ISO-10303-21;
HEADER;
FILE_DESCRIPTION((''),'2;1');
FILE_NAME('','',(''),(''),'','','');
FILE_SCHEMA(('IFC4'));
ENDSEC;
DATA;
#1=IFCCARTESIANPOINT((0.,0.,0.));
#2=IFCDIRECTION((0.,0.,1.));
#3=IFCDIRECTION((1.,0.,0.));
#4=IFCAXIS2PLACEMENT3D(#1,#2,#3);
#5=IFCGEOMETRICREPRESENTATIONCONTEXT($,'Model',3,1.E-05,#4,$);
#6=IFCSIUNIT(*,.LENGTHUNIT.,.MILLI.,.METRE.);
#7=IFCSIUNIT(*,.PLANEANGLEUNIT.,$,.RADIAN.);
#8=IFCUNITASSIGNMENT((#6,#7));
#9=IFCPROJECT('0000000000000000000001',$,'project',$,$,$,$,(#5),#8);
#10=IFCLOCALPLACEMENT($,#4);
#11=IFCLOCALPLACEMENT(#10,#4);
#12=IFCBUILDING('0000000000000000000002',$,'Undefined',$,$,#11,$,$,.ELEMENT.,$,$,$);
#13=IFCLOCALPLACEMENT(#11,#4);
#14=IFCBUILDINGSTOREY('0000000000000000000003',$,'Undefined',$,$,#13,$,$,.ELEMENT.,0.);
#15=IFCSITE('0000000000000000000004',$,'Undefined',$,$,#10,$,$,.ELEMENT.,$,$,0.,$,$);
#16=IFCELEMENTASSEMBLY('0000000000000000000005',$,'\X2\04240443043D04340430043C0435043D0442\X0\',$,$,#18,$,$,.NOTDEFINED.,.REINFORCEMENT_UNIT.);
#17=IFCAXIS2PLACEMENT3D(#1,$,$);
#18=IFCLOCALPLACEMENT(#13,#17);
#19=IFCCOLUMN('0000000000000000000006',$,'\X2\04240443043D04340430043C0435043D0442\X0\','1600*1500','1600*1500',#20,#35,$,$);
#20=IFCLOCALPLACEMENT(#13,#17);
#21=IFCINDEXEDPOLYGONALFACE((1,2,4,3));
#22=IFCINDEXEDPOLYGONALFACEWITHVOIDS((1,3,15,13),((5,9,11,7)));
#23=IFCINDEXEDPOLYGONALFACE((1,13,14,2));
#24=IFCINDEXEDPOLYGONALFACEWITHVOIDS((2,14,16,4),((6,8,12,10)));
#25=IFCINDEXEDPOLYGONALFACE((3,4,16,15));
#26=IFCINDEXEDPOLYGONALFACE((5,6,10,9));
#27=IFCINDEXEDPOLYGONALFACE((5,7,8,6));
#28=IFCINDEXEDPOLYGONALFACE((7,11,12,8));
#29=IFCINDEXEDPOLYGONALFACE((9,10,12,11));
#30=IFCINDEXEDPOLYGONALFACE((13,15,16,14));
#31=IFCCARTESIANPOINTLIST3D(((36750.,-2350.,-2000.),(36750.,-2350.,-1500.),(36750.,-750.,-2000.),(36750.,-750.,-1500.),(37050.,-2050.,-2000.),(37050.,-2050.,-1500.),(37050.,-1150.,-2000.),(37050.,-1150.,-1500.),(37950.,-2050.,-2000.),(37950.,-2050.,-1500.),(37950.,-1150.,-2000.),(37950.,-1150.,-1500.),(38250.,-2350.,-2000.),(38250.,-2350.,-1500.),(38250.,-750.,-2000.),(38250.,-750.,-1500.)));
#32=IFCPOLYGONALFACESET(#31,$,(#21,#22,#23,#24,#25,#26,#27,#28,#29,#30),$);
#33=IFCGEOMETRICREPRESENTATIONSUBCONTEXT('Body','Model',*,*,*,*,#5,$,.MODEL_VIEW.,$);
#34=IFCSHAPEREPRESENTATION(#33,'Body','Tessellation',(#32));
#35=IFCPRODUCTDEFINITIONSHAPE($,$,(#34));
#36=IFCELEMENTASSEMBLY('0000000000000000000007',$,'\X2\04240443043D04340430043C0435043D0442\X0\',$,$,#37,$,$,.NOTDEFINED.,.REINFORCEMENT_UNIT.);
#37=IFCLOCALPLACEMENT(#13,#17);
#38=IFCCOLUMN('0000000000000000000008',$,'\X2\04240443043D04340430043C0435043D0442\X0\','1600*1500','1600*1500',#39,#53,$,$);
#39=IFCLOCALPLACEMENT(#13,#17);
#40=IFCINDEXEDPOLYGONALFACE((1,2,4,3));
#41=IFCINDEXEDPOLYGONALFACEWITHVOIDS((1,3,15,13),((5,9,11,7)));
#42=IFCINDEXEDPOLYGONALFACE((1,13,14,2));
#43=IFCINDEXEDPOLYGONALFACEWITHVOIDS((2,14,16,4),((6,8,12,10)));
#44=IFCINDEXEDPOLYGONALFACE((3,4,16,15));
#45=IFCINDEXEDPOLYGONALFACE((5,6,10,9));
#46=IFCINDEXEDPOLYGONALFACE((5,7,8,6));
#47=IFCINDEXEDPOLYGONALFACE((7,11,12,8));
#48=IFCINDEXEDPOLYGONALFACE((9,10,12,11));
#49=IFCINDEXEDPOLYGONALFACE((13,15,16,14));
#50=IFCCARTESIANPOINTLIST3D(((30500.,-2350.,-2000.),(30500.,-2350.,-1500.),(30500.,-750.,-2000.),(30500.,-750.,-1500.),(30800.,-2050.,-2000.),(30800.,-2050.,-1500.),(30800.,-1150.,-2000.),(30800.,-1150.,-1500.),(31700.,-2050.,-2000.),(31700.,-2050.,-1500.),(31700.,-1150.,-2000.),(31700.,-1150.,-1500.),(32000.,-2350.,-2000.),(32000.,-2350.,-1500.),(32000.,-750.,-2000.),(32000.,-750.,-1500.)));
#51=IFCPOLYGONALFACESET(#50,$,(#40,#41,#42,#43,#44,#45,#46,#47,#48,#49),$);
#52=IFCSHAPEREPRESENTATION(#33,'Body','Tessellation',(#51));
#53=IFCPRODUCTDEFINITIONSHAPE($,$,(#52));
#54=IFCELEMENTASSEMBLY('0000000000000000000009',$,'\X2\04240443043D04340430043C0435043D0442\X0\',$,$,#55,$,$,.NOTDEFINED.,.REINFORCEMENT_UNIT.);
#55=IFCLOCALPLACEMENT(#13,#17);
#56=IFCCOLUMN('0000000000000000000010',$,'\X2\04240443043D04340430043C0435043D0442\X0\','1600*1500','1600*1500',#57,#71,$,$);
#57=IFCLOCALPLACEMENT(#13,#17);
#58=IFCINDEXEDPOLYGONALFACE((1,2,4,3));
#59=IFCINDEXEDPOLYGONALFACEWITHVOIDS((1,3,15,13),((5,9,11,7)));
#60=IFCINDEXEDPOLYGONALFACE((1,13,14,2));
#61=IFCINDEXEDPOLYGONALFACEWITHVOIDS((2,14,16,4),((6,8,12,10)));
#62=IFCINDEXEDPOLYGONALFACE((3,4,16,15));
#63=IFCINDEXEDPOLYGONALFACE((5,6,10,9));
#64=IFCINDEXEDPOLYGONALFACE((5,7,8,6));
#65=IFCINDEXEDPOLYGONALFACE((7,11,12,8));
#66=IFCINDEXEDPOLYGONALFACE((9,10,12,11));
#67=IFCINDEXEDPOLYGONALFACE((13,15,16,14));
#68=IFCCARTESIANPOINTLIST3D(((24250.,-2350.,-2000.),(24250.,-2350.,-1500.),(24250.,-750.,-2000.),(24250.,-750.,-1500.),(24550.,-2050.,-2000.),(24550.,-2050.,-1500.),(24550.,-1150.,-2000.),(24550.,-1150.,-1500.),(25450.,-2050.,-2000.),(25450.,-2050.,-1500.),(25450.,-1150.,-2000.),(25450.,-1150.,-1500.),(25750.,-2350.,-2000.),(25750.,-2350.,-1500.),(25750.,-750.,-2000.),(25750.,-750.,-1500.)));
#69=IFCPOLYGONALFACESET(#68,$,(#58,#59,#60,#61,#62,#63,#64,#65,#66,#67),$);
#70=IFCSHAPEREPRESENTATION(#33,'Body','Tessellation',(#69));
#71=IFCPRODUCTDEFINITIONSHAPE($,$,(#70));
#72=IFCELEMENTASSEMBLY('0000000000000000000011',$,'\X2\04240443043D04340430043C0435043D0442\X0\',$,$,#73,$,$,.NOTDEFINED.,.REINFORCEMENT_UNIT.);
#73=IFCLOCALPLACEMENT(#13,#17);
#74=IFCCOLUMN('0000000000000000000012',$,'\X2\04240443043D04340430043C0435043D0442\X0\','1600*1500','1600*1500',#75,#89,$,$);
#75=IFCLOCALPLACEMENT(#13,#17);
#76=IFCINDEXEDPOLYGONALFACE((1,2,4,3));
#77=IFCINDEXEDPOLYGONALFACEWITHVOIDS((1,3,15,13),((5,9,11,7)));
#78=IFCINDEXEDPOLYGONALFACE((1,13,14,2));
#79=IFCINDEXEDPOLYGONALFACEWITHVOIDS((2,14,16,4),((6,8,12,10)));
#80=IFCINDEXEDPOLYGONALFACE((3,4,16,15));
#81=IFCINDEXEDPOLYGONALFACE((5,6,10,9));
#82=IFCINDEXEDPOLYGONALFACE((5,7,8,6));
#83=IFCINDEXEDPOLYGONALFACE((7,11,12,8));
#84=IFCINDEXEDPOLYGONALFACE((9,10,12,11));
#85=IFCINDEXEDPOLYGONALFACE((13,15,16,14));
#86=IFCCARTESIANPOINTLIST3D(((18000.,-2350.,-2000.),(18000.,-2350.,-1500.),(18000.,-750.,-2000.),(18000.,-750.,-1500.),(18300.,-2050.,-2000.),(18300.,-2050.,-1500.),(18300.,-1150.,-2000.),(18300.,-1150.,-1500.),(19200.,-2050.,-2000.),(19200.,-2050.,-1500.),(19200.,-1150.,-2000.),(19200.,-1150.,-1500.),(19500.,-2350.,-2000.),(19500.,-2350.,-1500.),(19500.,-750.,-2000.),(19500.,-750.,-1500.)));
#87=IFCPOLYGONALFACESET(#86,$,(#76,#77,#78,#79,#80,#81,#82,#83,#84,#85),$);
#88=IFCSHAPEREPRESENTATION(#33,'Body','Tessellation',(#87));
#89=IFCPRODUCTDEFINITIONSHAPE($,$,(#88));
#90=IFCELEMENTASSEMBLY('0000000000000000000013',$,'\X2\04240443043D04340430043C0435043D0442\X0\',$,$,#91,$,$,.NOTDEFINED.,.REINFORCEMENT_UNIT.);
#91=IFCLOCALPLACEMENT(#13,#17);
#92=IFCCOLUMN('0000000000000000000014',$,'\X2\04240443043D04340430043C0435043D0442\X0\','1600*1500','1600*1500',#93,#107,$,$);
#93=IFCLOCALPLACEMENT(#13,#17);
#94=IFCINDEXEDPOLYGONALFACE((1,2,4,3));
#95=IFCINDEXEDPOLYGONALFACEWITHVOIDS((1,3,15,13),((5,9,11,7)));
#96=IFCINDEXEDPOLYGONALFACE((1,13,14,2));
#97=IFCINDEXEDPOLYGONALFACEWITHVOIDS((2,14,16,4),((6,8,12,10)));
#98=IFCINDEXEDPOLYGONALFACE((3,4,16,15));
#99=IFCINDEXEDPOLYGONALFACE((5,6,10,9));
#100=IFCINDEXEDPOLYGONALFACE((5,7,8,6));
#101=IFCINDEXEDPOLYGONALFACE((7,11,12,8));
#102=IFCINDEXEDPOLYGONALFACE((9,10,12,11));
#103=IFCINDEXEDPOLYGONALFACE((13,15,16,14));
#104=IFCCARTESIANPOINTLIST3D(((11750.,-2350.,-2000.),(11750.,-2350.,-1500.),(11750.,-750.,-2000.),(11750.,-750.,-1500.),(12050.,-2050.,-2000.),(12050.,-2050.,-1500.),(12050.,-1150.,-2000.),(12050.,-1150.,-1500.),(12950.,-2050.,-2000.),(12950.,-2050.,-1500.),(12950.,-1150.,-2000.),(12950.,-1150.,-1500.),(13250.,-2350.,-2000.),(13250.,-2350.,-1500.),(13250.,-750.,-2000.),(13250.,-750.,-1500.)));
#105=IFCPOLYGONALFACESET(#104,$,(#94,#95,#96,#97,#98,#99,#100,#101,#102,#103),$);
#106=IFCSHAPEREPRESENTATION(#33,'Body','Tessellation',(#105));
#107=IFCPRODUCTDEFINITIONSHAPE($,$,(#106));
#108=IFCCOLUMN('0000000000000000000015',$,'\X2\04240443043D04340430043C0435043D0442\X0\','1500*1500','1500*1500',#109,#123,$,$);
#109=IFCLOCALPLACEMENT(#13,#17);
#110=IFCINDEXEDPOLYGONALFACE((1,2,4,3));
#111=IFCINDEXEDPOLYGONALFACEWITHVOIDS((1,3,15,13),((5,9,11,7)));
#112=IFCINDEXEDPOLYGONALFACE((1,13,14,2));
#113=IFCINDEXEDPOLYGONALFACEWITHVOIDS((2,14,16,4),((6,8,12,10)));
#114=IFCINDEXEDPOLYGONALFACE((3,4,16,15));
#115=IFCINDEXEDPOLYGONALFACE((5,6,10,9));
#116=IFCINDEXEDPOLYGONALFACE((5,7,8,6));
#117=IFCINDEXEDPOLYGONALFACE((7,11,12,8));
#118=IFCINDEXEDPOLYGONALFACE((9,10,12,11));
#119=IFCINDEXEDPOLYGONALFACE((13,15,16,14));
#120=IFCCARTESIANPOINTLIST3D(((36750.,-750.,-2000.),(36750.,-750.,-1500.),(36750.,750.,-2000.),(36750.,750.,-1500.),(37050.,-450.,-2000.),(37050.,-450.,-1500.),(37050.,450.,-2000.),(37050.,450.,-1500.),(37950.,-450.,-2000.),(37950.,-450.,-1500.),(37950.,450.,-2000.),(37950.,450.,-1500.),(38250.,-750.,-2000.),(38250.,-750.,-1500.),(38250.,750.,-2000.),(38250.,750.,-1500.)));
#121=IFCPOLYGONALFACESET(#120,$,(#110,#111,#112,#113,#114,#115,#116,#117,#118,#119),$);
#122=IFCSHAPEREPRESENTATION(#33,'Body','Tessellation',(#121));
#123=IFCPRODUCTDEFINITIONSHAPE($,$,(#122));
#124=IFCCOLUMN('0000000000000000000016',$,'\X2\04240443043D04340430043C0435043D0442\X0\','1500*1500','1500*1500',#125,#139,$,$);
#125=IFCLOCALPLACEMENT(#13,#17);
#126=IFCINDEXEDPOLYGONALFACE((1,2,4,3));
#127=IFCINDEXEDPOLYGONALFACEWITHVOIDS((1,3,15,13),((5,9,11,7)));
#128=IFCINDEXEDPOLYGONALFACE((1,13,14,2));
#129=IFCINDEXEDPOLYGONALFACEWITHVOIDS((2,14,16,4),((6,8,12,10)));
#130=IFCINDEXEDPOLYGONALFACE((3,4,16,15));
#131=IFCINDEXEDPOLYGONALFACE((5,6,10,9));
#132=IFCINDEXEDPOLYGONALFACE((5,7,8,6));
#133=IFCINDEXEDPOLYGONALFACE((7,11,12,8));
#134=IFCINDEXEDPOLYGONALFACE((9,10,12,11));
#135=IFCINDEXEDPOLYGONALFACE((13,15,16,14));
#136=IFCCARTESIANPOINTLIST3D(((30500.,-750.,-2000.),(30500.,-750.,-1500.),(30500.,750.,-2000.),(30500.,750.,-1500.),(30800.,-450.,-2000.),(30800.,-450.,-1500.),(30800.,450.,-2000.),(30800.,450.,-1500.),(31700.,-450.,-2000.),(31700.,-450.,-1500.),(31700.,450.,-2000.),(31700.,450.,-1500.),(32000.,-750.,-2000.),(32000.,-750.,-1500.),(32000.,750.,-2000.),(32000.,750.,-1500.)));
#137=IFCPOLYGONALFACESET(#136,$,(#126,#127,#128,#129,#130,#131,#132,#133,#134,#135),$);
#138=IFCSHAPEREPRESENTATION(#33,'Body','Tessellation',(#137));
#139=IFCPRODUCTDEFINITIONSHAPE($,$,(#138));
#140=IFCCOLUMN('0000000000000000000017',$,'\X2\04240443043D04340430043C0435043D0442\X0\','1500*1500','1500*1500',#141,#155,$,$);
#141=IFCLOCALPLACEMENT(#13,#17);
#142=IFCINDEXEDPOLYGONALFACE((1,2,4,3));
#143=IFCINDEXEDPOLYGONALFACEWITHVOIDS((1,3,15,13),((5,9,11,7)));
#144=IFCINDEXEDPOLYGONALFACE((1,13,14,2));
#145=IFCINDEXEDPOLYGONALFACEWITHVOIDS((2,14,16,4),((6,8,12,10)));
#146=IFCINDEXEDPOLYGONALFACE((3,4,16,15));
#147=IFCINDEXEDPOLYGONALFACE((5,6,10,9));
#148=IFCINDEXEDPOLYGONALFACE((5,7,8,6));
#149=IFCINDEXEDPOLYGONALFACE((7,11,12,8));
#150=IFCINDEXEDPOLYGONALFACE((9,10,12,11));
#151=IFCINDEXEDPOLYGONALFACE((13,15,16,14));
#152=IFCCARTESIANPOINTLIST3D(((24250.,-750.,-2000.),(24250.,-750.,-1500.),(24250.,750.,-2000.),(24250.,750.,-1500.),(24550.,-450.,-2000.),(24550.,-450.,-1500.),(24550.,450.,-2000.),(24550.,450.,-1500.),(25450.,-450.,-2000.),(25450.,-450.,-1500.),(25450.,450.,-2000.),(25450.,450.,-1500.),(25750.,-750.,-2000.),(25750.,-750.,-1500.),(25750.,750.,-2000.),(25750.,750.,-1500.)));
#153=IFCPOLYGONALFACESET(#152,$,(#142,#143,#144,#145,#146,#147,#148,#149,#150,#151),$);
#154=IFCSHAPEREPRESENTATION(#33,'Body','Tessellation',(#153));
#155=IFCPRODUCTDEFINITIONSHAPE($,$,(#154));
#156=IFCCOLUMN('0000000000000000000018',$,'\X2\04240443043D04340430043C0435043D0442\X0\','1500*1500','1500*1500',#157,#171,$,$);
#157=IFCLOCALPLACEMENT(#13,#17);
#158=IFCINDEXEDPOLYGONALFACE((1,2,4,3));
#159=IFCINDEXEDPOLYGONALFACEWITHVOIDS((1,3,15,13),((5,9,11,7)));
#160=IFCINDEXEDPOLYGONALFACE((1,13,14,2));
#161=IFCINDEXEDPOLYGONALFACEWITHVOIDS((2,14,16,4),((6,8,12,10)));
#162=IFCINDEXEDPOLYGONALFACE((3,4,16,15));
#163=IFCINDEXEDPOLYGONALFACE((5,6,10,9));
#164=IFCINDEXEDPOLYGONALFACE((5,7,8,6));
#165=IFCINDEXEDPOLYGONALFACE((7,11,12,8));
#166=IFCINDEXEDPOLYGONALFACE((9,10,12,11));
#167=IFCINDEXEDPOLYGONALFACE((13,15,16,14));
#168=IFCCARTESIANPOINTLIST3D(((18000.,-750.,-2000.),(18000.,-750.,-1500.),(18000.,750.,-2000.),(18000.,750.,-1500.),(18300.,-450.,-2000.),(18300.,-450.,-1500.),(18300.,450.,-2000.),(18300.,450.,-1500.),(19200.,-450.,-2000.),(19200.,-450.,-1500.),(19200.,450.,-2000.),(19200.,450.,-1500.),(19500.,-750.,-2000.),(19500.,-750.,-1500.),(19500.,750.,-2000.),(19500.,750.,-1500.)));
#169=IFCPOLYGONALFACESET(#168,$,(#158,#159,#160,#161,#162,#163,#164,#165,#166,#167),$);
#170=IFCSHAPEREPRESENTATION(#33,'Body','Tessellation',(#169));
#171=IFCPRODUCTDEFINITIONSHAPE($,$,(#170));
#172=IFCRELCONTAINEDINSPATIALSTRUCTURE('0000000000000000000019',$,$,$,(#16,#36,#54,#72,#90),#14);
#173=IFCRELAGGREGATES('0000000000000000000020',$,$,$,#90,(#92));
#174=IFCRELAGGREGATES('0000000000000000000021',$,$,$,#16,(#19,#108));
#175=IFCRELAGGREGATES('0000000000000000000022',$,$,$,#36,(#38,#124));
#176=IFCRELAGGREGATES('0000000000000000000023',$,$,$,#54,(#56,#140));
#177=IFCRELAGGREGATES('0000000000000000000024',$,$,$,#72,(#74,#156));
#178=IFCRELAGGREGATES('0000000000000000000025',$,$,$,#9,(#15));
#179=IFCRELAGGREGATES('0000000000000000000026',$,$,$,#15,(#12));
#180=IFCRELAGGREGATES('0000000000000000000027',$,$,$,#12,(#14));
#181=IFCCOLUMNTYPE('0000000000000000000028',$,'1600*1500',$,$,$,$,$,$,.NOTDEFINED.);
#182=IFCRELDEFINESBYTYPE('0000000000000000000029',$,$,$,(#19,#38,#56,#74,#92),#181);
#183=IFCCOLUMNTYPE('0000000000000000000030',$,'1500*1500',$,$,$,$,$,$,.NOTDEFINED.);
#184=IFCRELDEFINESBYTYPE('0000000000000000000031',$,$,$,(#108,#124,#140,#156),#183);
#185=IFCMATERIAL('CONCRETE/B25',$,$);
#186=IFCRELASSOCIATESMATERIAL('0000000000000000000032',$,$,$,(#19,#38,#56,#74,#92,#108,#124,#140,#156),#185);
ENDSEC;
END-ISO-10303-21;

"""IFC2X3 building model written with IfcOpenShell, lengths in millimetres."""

from ifc_helpers import new_model, si_unit, frame, origin_with_axes, origin_2d_with_axis, place, context, subcontext, project, spatial, polyline, rectangle, outline, extrude, boolean, material, type_object, element, aggregate, save


model = new_model("IFC2X3")

# Units and contexts
model_context = context("Model", 3, precision=1e-05, world=origin_with_axes())
body_context = subcontext(model_context, "Body", "Model", "MODEL_VIEW")
ifc_project = project(units=[si_unit("LENGTHUNIT", "METRE", prefix="MILLI"), si_unit("PLANEANGLEUNIT", "RADIAN")], contexts=[model_context])

# Site, building, storey
site_placement = place(None, origin_with_axes())
site = spatial("IfcSite", under=ifc_project, at=site_placement, Name="Undefined", CompositionType="ELEMENT", RefElevation=0.0)
building_placement = place(site_placement, origin_with_axes())
building = spatial("IfcBuilding", under=site, at=building_placement, Name="Undefined", CompositionType="ELEMENT")
storey_placement = place(building_placement, origin_with_axes())
storey = spatial("IfcBuildingStorey", under=building, at=storey_placement, Name="Undefined", CompositionType="ELEMENT", Elevation=0.0)

# Element assemblies, columns
assembly_1_placement = place(storey_placement, origin_with_axes())
assembly_1 = element("IfcElementAssembly", 1, at=assembly_1_placement, inside=storey, Name="Фундамент", AssemblyPlace="NOTDEFINED", PredefinedType="REINFORCEMENT_UNIT")
ifc_material = material(Name="CONCRETE/B25")
column_type_1 = type_object("IfcColumnType", Name="1600*1500", PredefinedType="NOTDEFINED")
column_1_placement = place(assembly_1_placement, frame((37500.0, -1550.0, -2000.0), z_axis=(0.0, 0.0, 1.0), x_axis=(0.0, -1.0, 0.0)))
column_1 = element("IfcColumn", 2, at=column_1_placement, type_object=column_type_1, material=ifc_material, Name="Фундамент", Description="1600*1500", ObjectType="1600*1500", context=body_context, shape_type="CSG", body=[
    boolean("DIFFERENCE", extrude(rectangle(XDim=1500.0, YDim=1600.0, at=origin_2d_with_axis()), frame((0.0, 0.0, 500.0), z_axis=(0.0, 0.0, -1.0), x_axis=(0.0, 1.0, 0.0)), (0.0, 0.0, 1.0), 500.0), extrude(outline(polyline([(0.0, 0.0), (900.0, 0.0), (900.0, 900.0), (0.0, 900.0), (0.0, 0.0)])), frame((-400.0, -450.0, -100.0), z_axis=(0.0, 0.0, 1.0), x_axis=(1.0, 0.0, 0.0)), (0.0, 0.0, 1.0), 700.0)),
])
assembly_2_placement = place(storey_placement, origin_with_axes())
assembly_2 = element("IfcElementAssembly", 3, at=assembly_2_placement, inside=storey, Name="Фундамент", AssemblyPlace="NOTDEFINED", PredefinedType="REINFORCEMENT_UNIT")
column_2_placement = place(assembly_2_placement, frame((31250.0, -1550.0, -2000.0), z_axis=(0.0, 0.0, 1.0), x_axis=(0.0, -1.0, 0.0)))
column_2 = element("IfcColumn", 4, at=column_2_placement, type_object=column_type_1, material=ifc_material, Name="Фундамент", Description="1600*1500", ObjectType="1600*1500", context=body_context, shape_type="CSG", body=[
    boolean("DIFFERENCE", extrude(rectangle(XDim=1500.0, YDim=1600.0, at=origin_2d_with_axis()), frame((0.0, 0.0, 500.0), z_axis=(0.0, 0.0, -1.0), x_axis=(0.0, 1.0, 0.0)), (0.0, 0.0, 1.0), 500.0), extrude(outline(polyline([(0.0, 0.0), (900.0, 0.0), (900.0, 900.0), (0.0, 900.0), (0.0, 0.0)])), frame((-400.0, -450.0, -100.0), z_axis=(0.0, 0.0, 1.0), x_axis=(1.0, 0.0, 0.0)), (0.0, 0.0, 1.0), 700.0)),
])
assembly_3_placement = place(storey_placement, origin_with_axes())
assembly_3 = element("IfcElementAssembly", 5, at=assembly_3_placement, inside=storey, Name="Фундамент", AssemblyPlace="NOTDEFINED", PredefinedType="REINFORCEMENT_UNIT")
column_3_placement = place(assembly_3_placement, frame((25000.0, -1550.0, -2000.0), z_axis=(0.0, 0.0, 1.0), x_axis=(0.0, -1.0, 0.0)))
column_3 = element("IfcColumn", 6, at=column_3_placement, type_object=column_type_1, material=ifc_material, Name="Фундамент", Description="1600*1500", ObjectType="1600*1500", context=body_context, shape_type="CSG", body=[
    boolean("DIFFERENCE", extrude(rectangle(XDim=1500.0, YDim=1600.0, at=origin_2d_with_axis()), frame((0.0, 0.0, 500.0), z_axis=(0.0, 0.0, -1.0), x_axis=(0.0, 1.0, 0.0)), (0.0, 0.0, 1.0), 500.0), extrude(outline(polyline([(0.0, 0.0), (900.0, 0.0), (900.0, 900.0), (0.0, 900.0), (0.0, 0.0)])), frame((-400.0, -450.0, -100.0), z_axis=(0.0, 0.0, 1.0), x_axis=(1.0, 0.0, 0.0)), (0.0, 0.0, 1.0), 700.0)),
])
assembly_4_placement = place(storey_placement, origin_with_axes())
assembly_4 = element("IfcElementAssembly", 7, at=assembly_4_placement, inside=storey, Name="Фундамент", AssemblyPlace="NOTDEFINED", PredefinedType="REINFORCEMENT_UNIT")
column_4_placement = place(assembly_4_placement, frame((18750.0, -1550.0, -2000.0), z_axis=(0.0, 0.0, 1.0), x_axis=(0.0, -1.0, 0.0)))
column_4 = element("IfcColumn", 8, at=column_4_placement, type_object=column_type_1, material=ifc_material, Name="Фундамент", Description="1600*1500", ObjectType="1600*1500", context=body_context, shape_type="CSG", body=[
    boolean("DIFFERENCE", extrude(rectangle(XDim=1500.0, YDim=1600.0, at=origin_2d_with_axis()), frame((0.0, 0.0, 500.0), z_axis=(0.0, 0.0, -1.0), x_axis=(0.0, 1.0, 0.0)), (0.0, 0.0, 1.0), 500.0), extrude(outline(polyline([(0.0, 0.0), (900.0, 0.0), (900.0, 900.0), (0.0, 900.0), (0.0, 0.0)])), frame((-400.0, -450.0, -100.0), z_axis=(0.0, 0.0, 1.0), x_axis=(1.0, 0.0, 0.0)), (0.0, 0.0, 1.0), 700.0)),
])
assembly_5_placement = place(storey_placement, origin_with_axes())
assembly_5 = element("IfcElementAssembly", 9, at=assembly_5_placement, inside=storey, Name="Фундамент", AssemblyPlace="NOTDEFINED", PredefinedType="REINFORCEMENT_UNIT")
column_5_placement = place(assembly_5_placement, frame((12500.0, -1550.0, -2000.0), z_axis=(0.0, 0.0, 1.0), x_axis=(0.0, -1.0, 0.0)))
column_5 = element("IfcColumn", 10, at=column_5_placement, type_object=column_type_1, material=ifc_material, Name="Фундамент", Description="1600*1500", ObjectType="1600*1500", context=body_context, shape_type="CSG", body=[
    boolean("DIFFERENCE", extrude(rectangle(XDim=1500.0, YDim=1600.0, at=origin_2d_with_axis()), frame((0.0, 0.0, 500.0), z_axis=(0.0, 0.0, -1.0), x_axis=(0.0, 1.0, 0.0)), (0.0, 0.0, 1.0), 500.0), extrude(outline(polyline([(0.0, 0.0), (900.0, 0.0), (900.0, 900.0), (0.0, 900.0), (0.0, 0.0)])), frame((-400.0, -450.0, -100.0), z_axis=(0.0, 0.0, 1.0), x_axis=(1.0, 0.0, 0.0)), (0.0, 0.0, 1.0), 700.0)),
])

# Columns
column_type_2 = type_object("IfcColumnType", Name="1500*1500", PredefinedType="NOTDEFINED")
column_6_placement = place(assembly_1_placement, frame((37500.0, 0.0, -2000.0), z_axis=(0.0, 0.0, 1.0), x_axis=(0.0, -1.0, 0.0)))
column_6 = element("IfcColumn", 11, at=column_6_placement, type_object=column_type_2, material=ifc_material, Name="Фундамент", Description="1500*1500", ObjectType="1500*1500", context=body_context, shape_type="CSG", body=[
    boolean("DIFFERENCE", extrude(rectangle(XDim=1500.0, YDim=1500.0, at=origin_2d_with_axis()), frame((0.0, 0.0, 500.0), z_axis=(0.0, 0.0, -1.0), x_axis=(0.0, 1.0, 0.0)), (0.0, 0.0, 1.0), 500.0), extrude(outline(polyline([(0.0, 0.0), (900.0, 0.0), (900.0, 900.0), (0.0, 900.0), (0.0, 0.0)])), frame((-450.0, -450.0, -100.0), z_axis=(0.0, 0.0, 1.0), x_axis=(1.0, 0.0, 0.0)), (0.0, 0.0, 1.0), 700.0)),
])
column_7_placement = place(assembly_2_placement, frame((31250.0, 0.0, -2000.0), z_axis=(0.0, 0.0, 1.0), x_axis=(0.0, -1.0, 0.0)))
column_7 = element("IfcColumn", 12, at=column_7_placement, type_object=column_type_2, material=ifc_material, Name="Фундамент", Description="1500*1500", ObjectType="1500*1500", context=body_context, shape_type="CSG", body=[
    boolean("DIFFERENCE", extrude(rectangle(XDim=1500.0, YDim=1500.0, at=origin_2d_with_axis()), frame((0.0, 0.0, 500.0), z_axis=(0.0, 0.0, -1.0), x_axis=(0.0, 1.0, 0.0)), (0.0, 0.0, 1.0), 500.0), extrude(outline(polyline([(0.0, 0.0), (900.0, 0.0), (900.0, 900.0), (0.0, 900.0), (0.0, 0.0)])), frame((-450.0, -450.0, -100.0), z_axis=(0.0, 0.0, 1.0), x_axis=(1.0, 0.0, 0.0)), (0.0, 0.0, 1.0), 700.0)),
])
column_8_placement = place(assembly_3_placement, frame((25000.0, 0.0, -2000.0), z_axis=(0.0, 0.0, 1.0), x_axis=(0.0, -1.0, 0.0)))
column_8 = element("IfcColumn", 13, at=column_8_placement, type_object=column_type_2, material=ifc_material, Name="Фундамент", Description="1500*1500", ObjectType="1500*1500", context=body_context, shape_type="CSG", body=[
    boolean("DIFFERENCE", extrude(rectangle(XDim=1500.0, YDim=1500.0, at=origin_2d_with_axis()), frame((0.0, 0.0, 500.0), z_axis=(0.0, 0.0, -1.0), x_axis=(0.0, 1.0, 0.0)), (0.0, 0.0, 1.0), 500.0), extrude(outline(polyline([(0.0, 0.0), (900.0, 0.0), (900.0, 900.0), (0.0, 900.0), (0.0, 0.0)])), frame((-450.0, -450.0, -100.0), z_axis=(0.0, 0.0, 1.0), x_axis=(1.0, 0.0, 0.0)), (0.0, 0.0, 1.0), 700.0)),
])
column_9_placement = place(assembly_4_placement, frame((18750.0, 0.0, -2000.0), z_axis=(0.0, 0.0, 1.0), x_axis=(0.0, -1.0, 0.0)))
column_9 = element("IfcColumn", 14, at=column_9_placement, type_object=column_type_2, material=ifc_material, Name="Фундамент", Description="1500*1500", ObjectType="1500*1500", context=body_context, shape_type="CSG", body=[
    boolean("DIFFERENCE", extrude(rectangle(XDim=1500.0, YDim=1500.0, at=origin_2d_with_axis()), frame((0.0, 0.0, 500.0), z_axis=(0.0, 0.0, -1.0), x_axis=(0.0, 1.0, 0.0)), (0.0, 0.0, 1.0), 500.0), extrude(outline(polyline([(0.0, 0.0), (900.0, 0.0), (900.0, 900.0), (0.0, 900.0), (0.0, 0.0)])), frame((-450.0, -450.0, -100.0), z_axis=(0.0, 0.0, 1.0), x_axis=(1.0, 0.0, 0.0)), (0.0, 0.0, 1.0), 700.0)),
])
aggregate(assembly_5, [column_5])

aggregate(assembly_1, [column_1, column_6])
aggregate(assembly_2, [column_2, column_7])
aggregate(assembly_3, [column_3, column_8])
aggregate(assembly_4, [column_4, column_9])

save(model, "model.ifc")
